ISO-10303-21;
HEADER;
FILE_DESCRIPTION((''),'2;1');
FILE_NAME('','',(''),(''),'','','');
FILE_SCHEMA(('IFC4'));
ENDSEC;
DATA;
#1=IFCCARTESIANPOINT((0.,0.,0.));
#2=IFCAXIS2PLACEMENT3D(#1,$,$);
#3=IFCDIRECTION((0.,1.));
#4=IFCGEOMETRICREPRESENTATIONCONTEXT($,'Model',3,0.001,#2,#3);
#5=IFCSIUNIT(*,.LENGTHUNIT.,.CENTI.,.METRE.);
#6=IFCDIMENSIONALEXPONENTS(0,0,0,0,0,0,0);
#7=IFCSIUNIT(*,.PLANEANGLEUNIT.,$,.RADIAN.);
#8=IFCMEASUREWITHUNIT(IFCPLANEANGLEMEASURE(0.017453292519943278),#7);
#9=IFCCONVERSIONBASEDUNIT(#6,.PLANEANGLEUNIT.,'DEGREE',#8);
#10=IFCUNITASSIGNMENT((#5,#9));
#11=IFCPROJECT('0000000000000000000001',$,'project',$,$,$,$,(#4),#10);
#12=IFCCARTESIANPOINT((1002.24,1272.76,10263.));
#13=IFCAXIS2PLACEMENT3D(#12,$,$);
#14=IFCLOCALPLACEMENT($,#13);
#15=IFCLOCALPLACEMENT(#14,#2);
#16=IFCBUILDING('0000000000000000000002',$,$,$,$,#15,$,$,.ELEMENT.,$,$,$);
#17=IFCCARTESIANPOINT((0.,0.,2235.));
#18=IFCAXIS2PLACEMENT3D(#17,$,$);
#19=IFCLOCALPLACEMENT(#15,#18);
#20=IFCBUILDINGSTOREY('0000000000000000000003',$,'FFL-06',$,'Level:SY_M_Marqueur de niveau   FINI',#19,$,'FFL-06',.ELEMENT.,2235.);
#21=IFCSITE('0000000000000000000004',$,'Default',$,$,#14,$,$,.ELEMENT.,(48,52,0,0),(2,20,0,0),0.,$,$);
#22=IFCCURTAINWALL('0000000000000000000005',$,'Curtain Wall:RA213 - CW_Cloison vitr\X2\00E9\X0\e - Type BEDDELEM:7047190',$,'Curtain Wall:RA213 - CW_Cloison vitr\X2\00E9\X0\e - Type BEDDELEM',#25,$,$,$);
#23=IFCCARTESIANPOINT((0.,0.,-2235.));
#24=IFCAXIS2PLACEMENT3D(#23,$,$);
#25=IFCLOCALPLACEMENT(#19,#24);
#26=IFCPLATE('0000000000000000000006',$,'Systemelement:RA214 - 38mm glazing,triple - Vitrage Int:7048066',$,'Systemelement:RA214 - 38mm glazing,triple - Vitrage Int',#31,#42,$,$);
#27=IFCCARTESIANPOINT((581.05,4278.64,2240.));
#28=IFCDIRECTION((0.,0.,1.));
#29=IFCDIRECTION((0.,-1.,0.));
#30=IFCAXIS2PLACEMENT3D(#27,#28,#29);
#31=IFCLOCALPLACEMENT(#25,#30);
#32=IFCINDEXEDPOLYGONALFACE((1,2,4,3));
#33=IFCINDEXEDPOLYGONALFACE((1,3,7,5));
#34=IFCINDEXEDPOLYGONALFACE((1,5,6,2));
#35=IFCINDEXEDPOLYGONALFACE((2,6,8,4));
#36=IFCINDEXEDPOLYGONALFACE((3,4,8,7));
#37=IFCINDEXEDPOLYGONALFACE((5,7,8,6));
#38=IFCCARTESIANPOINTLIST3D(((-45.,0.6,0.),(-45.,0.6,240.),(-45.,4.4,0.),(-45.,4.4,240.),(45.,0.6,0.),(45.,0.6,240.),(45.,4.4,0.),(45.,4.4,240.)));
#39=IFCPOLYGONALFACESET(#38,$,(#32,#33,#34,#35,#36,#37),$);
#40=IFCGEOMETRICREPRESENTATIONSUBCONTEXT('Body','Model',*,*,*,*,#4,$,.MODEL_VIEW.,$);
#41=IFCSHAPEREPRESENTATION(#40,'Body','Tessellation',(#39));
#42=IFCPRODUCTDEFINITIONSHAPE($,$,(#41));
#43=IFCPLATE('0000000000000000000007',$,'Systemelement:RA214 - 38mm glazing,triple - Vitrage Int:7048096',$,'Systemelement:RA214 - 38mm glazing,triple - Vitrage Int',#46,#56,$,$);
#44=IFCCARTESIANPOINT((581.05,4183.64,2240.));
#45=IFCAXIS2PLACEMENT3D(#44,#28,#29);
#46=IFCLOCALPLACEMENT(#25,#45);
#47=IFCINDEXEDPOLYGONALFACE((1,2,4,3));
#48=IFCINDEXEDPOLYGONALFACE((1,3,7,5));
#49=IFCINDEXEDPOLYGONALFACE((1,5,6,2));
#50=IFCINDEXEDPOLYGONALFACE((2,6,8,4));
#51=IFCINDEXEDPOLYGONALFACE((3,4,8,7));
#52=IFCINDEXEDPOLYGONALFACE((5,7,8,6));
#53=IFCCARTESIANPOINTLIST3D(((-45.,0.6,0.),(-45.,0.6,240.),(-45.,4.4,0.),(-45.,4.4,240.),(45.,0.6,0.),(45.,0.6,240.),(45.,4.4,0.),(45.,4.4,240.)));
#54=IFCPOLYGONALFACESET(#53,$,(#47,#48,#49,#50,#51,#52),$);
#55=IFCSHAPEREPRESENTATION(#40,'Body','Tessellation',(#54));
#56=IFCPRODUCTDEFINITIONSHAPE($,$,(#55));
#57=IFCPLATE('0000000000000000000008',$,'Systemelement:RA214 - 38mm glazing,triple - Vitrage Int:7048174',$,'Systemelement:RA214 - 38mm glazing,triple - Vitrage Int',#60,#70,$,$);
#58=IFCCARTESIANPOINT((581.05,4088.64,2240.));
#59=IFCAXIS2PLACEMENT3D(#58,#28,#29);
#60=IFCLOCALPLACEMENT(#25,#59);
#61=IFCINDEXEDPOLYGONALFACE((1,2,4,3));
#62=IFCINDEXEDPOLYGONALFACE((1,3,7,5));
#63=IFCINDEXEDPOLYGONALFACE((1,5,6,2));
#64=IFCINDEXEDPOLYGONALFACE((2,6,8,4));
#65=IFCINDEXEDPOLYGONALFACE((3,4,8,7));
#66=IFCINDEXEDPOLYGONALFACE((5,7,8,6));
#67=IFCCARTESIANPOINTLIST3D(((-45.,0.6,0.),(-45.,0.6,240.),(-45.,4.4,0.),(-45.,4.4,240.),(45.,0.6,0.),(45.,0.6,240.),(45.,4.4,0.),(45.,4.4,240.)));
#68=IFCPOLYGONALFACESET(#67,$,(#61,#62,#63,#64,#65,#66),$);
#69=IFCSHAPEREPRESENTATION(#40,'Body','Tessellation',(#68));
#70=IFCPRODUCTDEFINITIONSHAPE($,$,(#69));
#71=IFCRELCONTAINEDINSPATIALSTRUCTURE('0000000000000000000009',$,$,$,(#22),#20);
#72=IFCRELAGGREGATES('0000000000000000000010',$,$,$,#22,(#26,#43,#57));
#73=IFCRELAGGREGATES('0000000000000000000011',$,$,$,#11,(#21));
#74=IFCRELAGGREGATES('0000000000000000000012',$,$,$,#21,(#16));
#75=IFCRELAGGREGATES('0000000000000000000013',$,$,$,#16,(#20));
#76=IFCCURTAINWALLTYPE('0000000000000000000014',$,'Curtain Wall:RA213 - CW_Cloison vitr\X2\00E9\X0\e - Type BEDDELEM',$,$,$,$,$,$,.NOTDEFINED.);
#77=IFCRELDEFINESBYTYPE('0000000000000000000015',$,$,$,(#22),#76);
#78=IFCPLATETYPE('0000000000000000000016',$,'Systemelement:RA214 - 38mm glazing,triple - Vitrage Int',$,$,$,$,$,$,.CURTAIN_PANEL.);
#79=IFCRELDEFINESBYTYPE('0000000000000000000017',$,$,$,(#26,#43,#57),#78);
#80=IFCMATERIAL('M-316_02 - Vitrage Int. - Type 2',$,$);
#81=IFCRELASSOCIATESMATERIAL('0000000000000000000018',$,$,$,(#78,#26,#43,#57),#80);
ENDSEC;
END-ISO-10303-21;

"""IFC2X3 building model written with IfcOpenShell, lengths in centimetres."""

from ifc_helpers import new_model, entity, si_unit, converted_unit, direction, frame, frame_2d, origin, place, context, subcontext, project, spatial, rectangle, extrude, source, transform, mapped, material, type_object, type_shapes, element, aggregate, save


model = new_model("IFC2X3")

# Units and contexts
model_context = context("Model", 3, precision=0.001, world=origin(), true_north=direction((0.0, 1.0)))
body_context = subcontext(model_context, "Body", "Model", "MODEL_VIEW")
ifc_project = project(units=[si_unit("LENGTHUNIT", "METRE", prefix="CENTI"), converted_unit("PLANEANGLEUNIT", "DEGREE", entity("IfcPlaneAngleMeasure", 0.017453292519943278), si_unit("PLANEANGLEUNIT", "RADIAN"), dimensions=[0, 0, 0, 0, 0, 0, 0])], contexts=[model_context])

# Site, building, storey
site_placement = place(None, frame((1002.24, 1272.76, 10263.0)))
site = spatial("IfcSite", under=ifc_project, at=site_placement, Name="Default", CompositionType="ELEMENT", RefLatitude=(48, 52, 0, 0), RefLongitude=(2, 20, 0, 0), RefElevation=0.0)
building_placement = place(site_placement, origin())
building = spatial("IfcBuilding", under=site, at=building_placement, CompositionType="ELEMENT")
storey_placement = place(building_placement, frame((0.0, 0.0, 2235.0)))
storey = spatial("IfcBuildingStorey", under=building, at=storey_placement, Name="FFL-06", ObjectType="Level:SY_M_Marqueur de niveau   FINI", LongName="FFL-06", CompositionType="ELEMENT", Elevation=2235.0)

# Curtain wall
curtain_wall_type_1 = type_object("IfcCurtainWallType", Name="Curtain Wall:RA213 - CW_Cloison vitrée - Type BEDDELEM", PredefinedType="NOTDEFINED")
curtain_wall_1_placement = place(storey_placement, frame((0.0, 0.0, -2235.0)))
curtain_wall_1 = element("IfcCurtainWall", 1, at=curtain_wall_1_placement, inside=storey, type_object=curtain_wall_type_1, Name="Curtain Wall:RA213 - CW_Cloison vitrée - Type BEDDELEM:7047190", ObjectType="Curtain Wall:RA213 - CW_Cloison vitrée - Type BEDDELEM")

# Plates
ifc_material_1 = material(Name="M-316_02 - Vitrage Int. - Type 2")
plate_type = type_object("IfcPlateType", Name="Systemelement:RA214 - 38mm glazing,triple - Vitrage Int", PredefinedType="CURTAIN_PANEL", material=ifc_material_1)
shared_shape_1 = source(origin(), body_context, "Body", "SweptSolid", [
    extrude(rectangle(XDim=3.8, YDim=90.0, at=frame_2d((0.0, 0.0), x_axis=(1.0, 0.0))), frame((0.0, 2.5, 0.0), z_axis=(0.0, 0.0, 1.0), x_axis=(0.0, 1.0, 0.0)), (0.0, 0.0, 1.0), 240.0),
])
type_shapes(plate_type, [shared_shape_1])
plate_1_placement = place(curtain_wall_1_placement, frame((581.05, 4278.64, 2240.0), z_axis=(0.0, 0.0, 1.0), x_axis=(0.0, -1.0, 0.0)))
plate_1 = element("IfcPlate", 2, at=plate_1_placement, type_object=plate_type, material=ifc_material_1, Name="Systemelement:RA214 - 38mm glazing,triple - Vitrage Int:7048066", ObjectType="Systemelement:RA214 - 38mm glazing,triple - Vitrage Int", context=body_context, shape_type="MappedRepresentation", body=[
    mapped(shared_shape_1, transform((0.0, 0.0, 0.0), scale=1.0)),
])
plate_2_placement = place(curtain_wall_1_placement, frame((581.05, 4183.64, 2240.0), z_axis=(0.0, 0.0, 1.0), x_axis=(0.0, -1.0, 0.0)))
plate_2 = element("IfcPlate", 3, at=plate_2_placement, type_object=plate_type, material=ifc_material_1, Name="Systemelement:RA214 - 38mm glazing,triple - Vitrage Int:7048096", ObjectType="Systemelement:RA214 - 38mm glazing,triple - Vitrage Int", context=body_context, shape_type="MappedRepresentation", body=[
    mapped(shared_shape_1, transform((0.0, 0.0, 0.0), scale=1.0)),
])
plate_3_placement = place(curtain_wall_1_placement, frame((581.05, 4088.64, 2240.0), z_axis=(0.0, 0.0, 1.0), x_axis=(0.0, -1.0, 0.0)))
plate_3 = element("IfcPlate", 4, at=plate_3_placement, type_object=plate_type, material=ifc_material_1, Name="Systemelement:RA214 - 38mm glazing,triple - Vitrage Int:7048174", ObjectType="Systemelement:RA214 - 38mm glazing,triple - Vitrage Int", context=body_context, shape_type="MappedRepresentation", body=[
    mapped(shared_shape_1, transform((0.0, 0.0, 0.0), scale=1.0)),
])
aggregate(curtain_wall_1, [plate_1, plate_2, plate_3])

save(model, "model.ifc")
